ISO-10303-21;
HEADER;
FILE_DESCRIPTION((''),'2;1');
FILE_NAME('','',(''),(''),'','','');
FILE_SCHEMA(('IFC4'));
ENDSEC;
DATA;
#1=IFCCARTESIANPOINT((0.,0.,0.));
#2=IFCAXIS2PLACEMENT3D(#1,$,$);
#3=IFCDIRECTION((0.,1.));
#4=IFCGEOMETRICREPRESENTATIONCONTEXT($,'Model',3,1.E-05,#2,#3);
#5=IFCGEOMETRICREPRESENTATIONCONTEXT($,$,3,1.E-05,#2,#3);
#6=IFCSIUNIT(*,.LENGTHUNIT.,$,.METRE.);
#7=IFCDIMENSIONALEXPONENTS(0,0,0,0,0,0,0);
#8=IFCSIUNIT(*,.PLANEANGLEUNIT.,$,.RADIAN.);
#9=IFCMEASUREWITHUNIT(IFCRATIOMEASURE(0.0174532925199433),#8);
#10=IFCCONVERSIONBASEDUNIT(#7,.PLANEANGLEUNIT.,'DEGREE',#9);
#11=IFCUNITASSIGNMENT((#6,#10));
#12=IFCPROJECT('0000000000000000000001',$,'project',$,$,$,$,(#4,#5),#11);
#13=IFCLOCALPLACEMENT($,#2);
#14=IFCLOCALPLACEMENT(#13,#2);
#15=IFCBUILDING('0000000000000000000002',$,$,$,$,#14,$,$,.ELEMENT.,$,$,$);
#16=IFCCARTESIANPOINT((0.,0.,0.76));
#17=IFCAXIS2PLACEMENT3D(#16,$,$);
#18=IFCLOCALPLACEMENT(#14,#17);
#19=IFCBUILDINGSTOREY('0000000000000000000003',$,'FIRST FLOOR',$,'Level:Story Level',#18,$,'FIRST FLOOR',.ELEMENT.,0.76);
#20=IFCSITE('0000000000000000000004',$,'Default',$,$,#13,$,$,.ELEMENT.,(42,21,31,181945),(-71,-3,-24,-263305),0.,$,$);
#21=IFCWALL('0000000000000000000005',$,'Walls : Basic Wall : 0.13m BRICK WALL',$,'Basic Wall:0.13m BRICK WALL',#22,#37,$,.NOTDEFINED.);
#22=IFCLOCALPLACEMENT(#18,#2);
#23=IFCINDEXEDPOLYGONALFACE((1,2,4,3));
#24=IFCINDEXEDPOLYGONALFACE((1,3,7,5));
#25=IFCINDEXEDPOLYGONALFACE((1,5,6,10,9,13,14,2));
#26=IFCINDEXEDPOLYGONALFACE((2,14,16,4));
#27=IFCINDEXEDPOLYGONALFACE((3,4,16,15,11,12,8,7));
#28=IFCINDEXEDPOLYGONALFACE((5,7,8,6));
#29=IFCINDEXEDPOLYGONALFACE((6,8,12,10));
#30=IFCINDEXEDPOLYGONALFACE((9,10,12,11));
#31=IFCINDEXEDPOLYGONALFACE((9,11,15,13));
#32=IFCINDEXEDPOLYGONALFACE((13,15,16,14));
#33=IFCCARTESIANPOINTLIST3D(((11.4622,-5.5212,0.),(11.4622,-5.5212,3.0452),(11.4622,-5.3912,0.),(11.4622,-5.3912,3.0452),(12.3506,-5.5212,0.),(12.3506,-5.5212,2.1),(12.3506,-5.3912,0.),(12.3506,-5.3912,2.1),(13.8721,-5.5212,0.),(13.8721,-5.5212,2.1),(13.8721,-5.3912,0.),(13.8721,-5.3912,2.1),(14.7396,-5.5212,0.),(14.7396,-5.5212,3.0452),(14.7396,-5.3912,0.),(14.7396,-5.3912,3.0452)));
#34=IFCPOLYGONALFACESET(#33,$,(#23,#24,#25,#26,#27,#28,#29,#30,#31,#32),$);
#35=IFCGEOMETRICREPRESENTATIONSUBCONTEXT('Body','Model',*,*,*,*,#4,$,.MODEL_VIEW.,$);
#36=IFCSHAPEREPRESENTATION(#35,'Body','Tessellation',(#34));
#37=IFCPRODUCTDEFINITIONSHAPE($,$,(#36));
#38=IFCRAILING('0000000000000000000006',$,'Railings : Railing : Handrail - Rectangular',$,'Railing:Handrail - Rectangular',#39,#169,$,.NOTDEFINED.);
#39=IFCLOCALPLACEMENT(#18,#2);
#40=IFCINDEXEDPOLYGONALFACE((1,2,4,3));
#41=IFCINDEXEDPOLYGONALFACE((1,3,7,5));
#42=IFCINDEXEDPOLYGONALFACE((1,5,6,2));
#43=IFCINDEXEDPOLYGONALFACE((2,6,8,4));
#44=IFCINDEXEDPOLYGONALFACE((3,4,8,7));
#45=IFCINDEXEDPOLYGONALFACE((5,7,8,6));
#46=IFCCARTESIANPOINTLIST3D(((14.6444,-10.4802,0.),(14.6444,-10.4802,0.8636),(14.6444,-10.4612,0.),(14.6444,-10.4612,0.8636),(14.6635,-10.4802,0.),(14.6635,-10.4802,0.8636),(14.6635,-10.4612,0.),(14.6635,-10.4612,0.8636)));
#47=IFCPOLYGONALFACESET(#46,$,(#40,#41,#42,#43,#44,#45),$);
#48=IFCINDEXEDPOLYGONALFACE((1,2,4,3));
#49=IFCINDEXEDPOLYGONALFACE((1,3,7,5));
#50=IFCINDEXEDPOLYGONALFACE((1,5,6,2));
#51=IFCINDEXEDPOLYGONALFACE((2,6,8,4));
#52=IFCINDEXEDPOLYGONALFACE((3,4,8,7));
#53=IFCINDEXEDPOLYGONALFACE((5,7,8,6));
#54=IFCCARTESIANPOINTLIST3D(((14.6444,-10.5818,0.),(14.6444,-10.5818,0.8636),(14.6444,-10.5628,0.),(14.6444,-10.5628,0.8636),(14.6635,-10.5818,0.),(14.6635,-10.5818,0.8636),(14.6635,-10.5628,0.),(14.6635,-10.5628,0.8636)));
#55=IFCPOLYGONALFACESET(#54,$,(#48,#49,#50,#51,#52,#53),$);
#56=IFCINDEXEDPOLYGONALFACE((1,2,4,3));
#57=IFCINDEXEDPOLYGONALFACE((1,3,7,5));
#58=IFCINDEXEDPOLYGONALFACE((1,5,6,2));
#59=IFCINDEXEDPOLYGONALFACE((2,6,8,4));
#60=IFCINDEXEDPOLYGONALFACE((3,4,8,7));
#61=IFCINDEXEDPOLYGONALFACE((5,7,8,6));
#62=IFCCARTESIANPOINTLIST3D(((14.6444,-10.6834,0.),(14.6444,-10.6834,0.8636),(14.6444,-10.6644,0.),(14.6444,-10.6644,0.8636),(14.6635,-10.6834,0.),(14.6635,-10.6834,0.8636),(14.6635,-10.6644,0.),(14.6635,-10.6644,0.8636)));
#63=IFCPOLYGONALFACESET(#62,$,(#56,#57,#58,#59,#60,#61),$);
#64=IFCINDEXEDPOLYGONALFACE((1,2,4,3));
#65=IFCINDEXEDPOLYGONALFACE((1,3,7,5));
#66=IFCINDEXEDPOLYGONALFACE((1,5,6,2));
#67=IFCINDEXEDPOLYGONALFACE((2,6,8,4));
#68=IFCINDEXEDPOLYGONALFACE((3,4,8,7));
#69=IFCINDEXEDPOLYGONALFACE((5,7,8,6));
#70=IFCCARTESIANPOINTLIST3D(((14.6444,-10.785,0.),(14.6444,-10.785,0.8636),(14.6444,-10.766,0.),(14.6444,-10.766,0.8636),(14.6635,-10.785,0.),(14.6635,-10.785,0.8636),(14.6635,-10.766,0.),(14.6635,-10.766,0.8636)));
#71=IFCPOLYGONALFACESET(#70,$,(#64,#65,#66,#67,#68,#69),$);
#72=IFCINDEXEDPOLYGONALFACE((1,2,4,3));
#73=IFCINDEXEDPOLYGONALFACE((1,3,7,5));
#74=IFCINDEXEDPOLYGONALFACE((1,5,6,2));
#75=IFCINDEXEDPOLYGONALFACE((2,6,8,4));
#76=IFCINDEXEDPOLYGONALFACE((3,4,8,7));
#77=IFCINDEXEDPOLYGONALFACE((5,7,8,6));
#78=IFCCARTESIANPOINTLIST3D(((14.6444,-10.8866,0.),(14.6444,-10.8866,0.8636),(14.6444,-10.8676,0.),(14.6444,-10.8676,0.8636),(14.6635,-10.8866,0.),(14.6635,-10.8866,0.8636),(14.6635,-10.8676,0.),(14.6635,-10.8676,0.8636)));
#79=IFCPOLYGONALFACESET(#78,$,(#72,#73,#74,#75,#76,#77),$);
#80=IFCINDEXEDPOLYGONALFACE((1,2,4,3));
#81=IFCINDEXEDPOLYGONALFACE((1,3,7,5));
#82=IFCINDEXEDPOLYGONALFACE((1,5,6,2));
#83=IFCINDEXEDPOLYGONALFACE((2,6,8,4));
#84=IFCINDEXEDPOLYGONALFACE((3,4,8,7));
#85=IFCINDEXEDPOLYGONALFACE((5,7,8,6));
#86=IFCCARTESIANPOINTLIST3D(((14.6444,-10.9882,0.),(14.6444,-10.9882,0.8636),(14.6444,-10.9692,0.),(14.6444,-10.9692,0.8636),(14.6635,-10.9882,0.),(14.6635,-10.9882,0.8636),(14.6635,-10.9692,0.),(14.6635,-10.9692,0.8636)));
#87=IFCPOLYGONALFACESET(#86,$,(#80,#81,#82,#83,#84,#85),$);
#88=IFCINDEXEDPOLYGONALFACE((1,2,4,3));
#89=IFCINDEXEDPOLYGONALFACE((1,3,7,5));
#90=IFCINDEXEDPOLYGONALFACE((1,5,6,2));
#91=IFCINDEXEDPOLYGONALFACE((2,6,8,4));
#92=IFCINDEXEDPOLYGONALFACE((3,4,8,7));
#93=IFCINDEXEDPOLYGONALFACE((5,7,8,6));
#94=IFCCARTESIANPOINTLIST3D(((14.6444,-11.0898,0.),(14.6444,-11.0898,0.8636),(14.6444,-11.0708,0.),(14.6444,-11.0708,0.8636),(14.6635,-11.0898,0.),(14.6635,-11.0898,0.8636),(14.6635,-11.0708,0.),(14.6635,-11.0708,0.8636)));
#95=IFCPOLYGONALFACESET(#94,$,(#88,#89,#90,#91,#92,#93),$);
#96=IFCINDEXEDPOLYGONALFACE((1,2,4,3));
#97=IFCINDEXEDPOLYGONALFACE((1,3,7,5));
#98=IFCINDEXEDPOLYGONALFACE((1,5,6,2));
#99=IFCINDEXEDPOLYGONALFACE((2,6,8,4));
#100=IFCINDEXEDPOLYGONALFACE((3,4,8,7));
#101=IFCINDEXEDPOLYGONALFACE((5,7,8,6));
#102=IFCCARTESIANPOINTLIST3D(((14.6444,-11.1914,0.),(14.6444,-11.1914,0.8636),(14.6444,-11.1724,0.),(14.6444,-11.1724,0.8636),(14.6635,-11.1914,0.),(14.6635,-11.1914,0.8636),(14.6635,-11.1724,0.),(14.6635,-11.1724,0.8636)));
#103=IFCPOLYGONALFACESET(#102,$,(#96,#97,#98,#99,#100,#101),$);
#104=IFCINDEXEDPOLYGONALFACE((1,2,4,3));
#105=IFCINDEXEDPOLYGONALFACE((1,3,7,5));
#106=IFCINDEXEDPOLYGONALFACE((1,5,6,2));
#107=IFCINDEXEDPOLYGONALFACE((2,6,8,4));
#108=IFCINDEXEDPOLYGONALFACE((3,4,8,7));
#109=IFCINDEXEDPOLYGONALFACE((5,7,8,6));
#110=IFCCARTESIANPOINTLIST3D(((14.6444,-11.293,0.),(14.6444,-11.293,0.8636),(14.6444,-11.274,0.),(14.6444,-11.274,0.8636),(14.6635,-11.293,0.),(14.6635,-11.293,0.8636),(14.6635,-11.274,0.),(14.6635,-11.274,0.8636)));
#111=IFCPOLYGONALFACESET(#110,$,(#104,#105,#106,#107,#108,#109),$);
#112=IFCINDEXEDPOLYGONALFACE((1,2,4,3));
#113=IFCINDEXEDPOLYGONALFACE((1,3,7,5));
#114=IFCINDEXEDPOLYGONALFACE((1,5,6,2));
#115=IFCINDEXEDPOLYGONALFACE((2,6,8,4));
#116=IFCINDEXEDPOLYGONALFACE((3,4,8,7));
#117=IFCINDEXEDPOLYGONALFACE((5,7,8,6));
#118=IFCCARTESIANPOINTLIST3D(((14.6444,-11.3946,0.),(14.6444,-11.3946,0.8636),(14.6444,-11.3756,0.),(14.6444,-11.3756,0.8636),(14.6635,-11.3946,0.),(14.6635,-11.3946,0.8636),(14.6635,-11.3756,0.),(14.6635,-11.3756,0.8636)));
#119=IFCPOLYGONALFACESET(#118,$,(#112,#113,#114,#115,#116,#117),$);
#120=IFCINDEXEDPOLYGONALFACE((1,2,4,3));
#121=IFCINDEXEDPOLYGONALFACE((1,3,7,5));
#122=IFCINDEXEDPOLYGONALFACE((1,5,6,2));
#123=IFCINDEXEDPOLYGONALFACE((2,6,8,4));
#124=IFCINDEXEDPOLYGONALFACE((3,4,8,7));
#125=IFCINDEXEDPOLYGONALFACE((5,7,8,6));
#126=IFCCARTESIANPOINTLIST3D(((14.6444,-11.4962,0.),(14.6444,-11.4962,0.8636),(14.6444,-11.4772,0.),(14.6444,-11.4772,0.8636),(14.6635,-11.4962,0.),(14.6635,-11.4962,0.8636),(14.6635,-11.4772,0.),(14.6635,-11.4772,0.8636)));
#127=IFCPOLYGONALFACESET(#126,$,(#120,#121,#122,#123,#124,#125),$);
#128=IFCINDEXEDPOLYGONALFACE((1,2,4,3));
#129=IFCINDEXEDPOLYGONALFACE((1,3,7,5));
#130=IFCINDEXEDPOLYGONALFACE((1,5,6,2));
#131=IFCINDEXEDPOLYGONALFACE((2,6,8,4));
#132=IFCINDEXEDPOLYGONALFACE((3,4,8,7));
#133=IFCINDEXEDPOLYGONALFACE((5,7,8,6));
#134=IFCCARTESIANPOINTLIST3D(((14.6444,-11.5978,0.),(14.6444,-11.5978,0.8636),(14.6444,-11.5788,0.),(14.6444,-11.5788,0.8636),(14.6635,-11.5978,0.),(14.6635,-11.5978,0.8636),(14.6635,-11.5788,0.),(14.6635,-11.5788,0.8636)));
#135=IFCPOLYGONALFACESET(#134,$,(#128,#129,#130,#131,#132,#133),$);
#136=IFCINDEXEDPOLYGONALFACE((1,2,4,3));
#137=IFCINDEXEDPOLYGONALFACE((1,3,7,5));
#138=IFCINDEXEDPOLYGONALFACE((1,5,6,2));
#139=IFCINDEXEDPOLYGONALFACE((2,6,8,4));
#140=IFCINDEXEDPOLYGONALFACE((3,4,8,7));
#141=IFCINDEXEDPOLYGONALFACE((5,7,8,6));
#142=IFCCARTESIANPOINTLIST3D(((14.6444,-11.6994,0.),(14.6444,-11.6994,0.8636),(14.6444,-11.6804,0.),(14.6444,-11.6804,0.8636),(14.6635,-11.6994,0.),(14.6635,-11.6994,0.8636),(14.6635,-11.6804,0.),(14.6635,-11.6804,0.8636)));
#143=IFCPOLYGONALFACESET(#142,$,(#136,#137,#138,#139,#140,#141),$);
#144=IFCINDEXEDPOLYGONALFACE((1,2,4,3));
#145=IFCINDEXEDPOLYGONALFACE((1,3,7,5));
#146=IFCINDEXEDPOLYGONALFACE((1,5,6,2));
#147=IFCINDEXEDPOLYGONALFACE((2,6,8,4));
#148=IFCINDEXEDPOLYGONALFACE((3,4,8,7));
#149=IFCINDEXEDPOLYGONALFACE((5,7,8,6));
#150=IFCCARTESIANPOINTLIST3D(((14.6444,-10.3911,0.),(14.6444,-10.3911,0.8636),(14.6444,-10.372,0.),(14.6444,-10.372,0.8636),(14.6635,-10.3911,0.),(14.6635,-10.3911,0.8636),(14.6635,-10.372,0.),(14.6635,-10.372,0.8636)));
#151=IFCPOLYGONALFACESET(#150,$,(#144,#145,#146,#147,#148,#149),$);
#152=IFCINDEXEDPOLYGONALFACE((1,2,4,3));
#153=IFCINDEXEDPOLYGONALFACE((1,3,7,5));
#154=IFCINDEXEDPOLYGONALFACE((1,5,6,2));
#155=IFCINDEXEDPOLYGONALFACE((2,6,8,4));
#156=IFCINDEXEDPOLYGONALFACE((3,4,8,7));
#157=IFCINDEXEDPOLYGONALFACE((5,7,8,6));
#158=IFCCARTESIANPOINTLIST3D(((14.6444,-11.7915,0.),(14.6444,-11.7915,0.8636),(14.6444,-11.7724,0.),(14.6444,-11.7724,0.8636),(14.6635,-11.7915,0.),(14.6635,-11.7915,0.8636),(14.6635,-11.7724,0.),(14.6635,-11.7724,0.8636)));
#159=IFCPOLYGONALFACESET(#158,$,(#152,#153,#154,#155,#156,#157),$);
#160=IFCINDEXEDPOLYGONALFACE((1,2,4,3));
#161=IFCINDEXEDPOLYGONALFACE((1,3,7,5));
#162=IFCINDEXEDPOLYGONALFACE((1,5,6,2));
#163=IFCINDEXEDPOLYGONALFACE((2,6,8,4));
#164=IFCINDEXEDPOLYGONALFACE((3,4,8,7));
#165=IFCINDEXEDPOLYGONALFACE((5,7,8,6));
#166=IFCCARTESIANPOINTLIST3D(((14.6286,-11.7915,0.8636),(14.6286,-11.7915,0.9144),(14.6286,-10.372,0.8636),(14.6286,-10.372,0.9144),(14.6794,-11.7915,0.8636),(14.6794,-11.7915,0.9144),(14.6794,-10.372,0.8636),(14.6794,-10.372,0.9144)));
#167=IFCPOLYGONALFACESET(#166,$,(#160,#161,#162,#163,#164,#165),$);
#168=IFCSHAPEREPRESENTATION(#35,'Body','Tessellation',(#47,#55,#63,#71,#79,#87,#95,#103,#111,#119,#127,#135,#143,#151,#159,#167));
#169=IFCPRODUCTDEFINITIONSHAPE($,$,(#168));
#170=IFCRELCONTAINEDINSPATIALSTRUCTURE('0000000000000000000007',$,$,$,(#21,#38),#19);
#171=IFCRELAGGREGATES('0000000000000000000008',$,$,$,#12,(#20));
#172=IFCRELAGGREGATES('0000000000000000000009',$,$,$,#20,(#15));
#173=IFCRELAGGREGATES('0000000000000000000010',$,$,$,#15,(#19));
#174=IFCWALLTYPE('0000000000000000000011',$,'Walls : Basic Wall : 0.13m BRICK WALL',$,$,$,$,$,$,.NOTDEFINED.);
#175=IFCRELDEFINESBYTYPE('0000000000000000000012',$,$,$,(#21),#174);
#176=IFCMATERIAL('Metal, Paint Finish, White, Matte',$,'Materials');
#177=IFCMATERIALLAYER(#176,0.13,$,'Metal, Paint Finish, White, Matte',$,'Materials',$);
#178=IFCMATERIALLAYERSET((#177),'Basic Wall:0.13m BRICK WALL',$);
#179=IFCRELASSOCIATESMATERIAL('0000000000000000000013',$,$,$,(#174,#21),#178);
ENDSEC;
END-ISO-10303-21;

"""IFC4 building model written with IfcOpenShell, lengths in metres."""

from ifc_helpers import new_model, entity, si_unit, converted_unit, direction, frame, frame_2d, origin, origin_2d_with_axis, place, context, subcontext, project, spatial, rectangle, extrude, material, layer, layer_set, layer_usage, type_object, element, save


model = new_model("IFC4")

# Units and contexts
model_context = context("Model", 3, precision=1e-05, world=origin(), true_north=direction((0.0, 1.0)))
context_of_model = context(None, 3, precision=1e-05, world=origin(), true_north=direction((0.0, 1.0)))
body_context = subcontext(model_context, "Body", "Model", "MODEL_VIEW")
ifc_project = project(units=[si_unit("LENGTHUNIT", "METRE"), converted_unit("PLANEANGLEUNIT", "DEGREE", entity("IfcRatioMeasure", 0.0174532925199433), si_unit("PLANEANGLEUNIT", "RADIAN"), dimensions=[0, 0, 0, 0, 0, 0, 0])], contexts=[model_context, context_of_model])

# Site, building, storey
site_placement = place(None, origin())
site = spatial("IfcSite", under=ifc_project, at=site_placement, Name="Default", CompositionType="ELEMENT", RefLatitude=(42, 21, 31, 181945), RefLongitude=(-71, -3, -24, -263305), RefElevation=0.0)
building_placement = place(site_placement, origin())
building = spatial("IfcBuilding", under=site, at=building_placement, CompositionType="ELEMENT")
storey_placement = place(building_placement, frame((0.0, 0.0, 0.76)))
storey = spatial("IfcBuildingStorey", under=building, at=storey_placement, Name="FIRST FLOOR", ObjectType="Level:Story Level", LongName="FIRST FLOOR", CompositionType="ELEMENT", Elevation=0.76)

# Wall, opening
ifc_material_1 = material(Name="Metal, Paint Finish, White, Matte", Category="Materials")
ifc_layer_1 = layer(ifc_material_1, 0.13, Name="Metal, Paint Finish, White, Matte", Category="Materials")
ifc_layer_set_1 = layer_set([ifc_layer_1], Name="Basic Wall:0.13m BRICK WALL")
ifc_layer_usage_1 = layer_usage(ifc_layer_set_1, "AXIS2", "NEGATIVE", 0.065)
wall_type_1 = type_object("IfcWallType", Name="Walls : Basic Wall : 0.13m BRICK WALL", PredefinedType="NOTDEFINED", material=ifc_layer_set_1)
wall_1_placement = place(storey_placement, frame((14.7396, -5.4562, 0.0), z_axis=(0.0, 0.0, 1.0), x_axis=(-1.0, 0.0, 0.0)))
wall_1 = element("IfcWall", 1, at=wall_1_placement, inside=storey, type_object=wall_type_1, material=ifc_layer_usage_1, Name="Walls : Basic Wall : 0.13m BRICK WALL", ObjectType="Basic Wall:0.13m BRICK WALL", PredefinedType="NOTDEFINED", context=body_context, shape_type="SweptSolid", body=[
    extrude(rectangle(XDim=3.2774, YDim=0.13, at=frame_2d((1.6387, 0.0), x_axis=(-1.0, 0.0))), origin(), (0.0, 0.0, 1.0), 3.0452),
])
opening_1_placement = place(wall_1_placement, frame((2.389, 0.065, 0.0)))
element("IfcOpeningElement", 2, at=opening_1_placement, cuts=wall_1, ObjectType="Opening", PredefinedType="OPENING", context=body_context, shape_type="SweptSolid", body=[
    extrude(rectangle(XDim=2.1, YDim=1.5215, at=frame_2d((0.0, 0.0), x_axis=(1.0, 0.0))), frame((-0.7607, -0.13, 1.05), z_axis=(0.0, 1.0, 0.0), x_axis=(0.0, 0.0, -1.0)), (0.0, 0.0, 1.0), 0.13),
])

# Railing
railing_placement = place(storey_placement, frame((14.6286, -11.7915, 0.0)))
element("IfcRailing", 3, at=railing_placement, inside=storey, Name="Railings : Railing : Handrail - Rectangular", ObjectType="Railing:Handrail - Rectangular", PredefinedType="NOTDEFINED", context=body_context, shape_type="SweptSolid", body=[
    extrude(rectangle(XDim=0.0191, YDim=0.0191, at=origin_2d_with_axis()), frame((0.0254, 1.3208, 0.0), z_axis=(0.0, 0.0, 1.0), x_axis=(0.0, 1.0, 0.0)), (0.0, 0.0, 1.0), 0.8636),
    extrude(rectangle(XDim=0.0191, YDim=0.0191, at=origin_2d_with_axis()), frame((0.0254, 1.2192, 0.0), z_axis=(0.0, 0.0, 1.0), x_axis=(0.0, 1.0, 0.0)), (0.0, 0.0, 1.0), 0.8636),
    extrude(rectangle(XDim=0.0191, YDim=0.0191, at=origin_2d_with_axis()), frame((0.0254, 1.1176, 0.0), z_axis=(0.0, 0.0, 1.0), x_axis=(0.0, 1.0, 0.0)), (0.0, 0.0, 1.0), 0.8636),
    extrude(rectangle(XDim=0.0191, YDim=0.0191, at=origin_2d_with_axis()), frame((0.0254, 1.016, 0.0), z_axis=(0.0, 0.0, 1.0), x_axis=(0.0, 1.0, 0.0)), (0.0, 0.0, 1.0), 0.8636),
    extrude(rectangle(XDim=0.0191, YDim=0.0191, at=origin_2d_with_axis()), frame((0.0254, 0.9144, 0.0), z_axis=(0.0, 0.0, 1.0), x_axis=(0.0, 1.0, 0.0)), (0.0, 0.0, 1.0), 0.8636),
    extrude(rectangle(XDim=0.0191, YDim=0.0191, at=origin_2d_with_axis()), frame((0.0254, 0.8128, 0.0), z_axis=(0.0, 0.0, 1.0), x_axis=(0.0, 1.0, 0.0)), (0.0, 0.0, 1.0), 0.8636),
    extrude(rectangle(XDim=0.0191, YDim=0.0191, at=origin_2d_with_axis()), frame((0.0254, 0.7112, 0.0), z_axis=(0.0, 0.0, 1.0), x_axis=(0.0, 1.0, 0.0)), (0.0, 0.0, 1.0), 0.8636),
    extrude(rectangle(XDim=0.0191, YDim=0.0191, at=origin_2d_with_axis()), frame((0.0254, 0.6096, 0.0), z_axis=(0.0, 0.0, 1.0), x_axis=(0.0, 1.0, 0.0)), (0.0, 0.0, 1.0), 0.8636),
    extrude(rectangle(XDim=0.0191, YDim=0.0191, at=origin_2d_with_axis()), frame((0.0254, 0.508, 0.0), z_axis=(0.0, 0.0, 1.0), x_axis=(0.0, 1.0, 0.0)), (0.0, 0.0, 1.0), 0.8636),
    extrude(rectangle(XDim=0.0191, YDim=0.0191, at=origin_2d_with_axis()), frame((0.0254, 0.4064, 0.0), z_axis=(0.0, 0.0, 1.0), x_axis=(0.0, 1.0, 0.0)), (0.0, 0.0, 1.0), 0.8636),
    extrude(rectangle(XDim=0.0191, YDim=0.0191, at=origin_2d_with_axis()), frame((0.0254, 0.3048, 0.0), z_axis=(0.0, 0.0, 1.0), x_axis=(0.0, 1.0, 0.0)), (0.0, 0.0, 1.0), 0.8636),
    extrude(rectangle(XDim=0.0191, YDim=0.0191, at=origin_2d_with_axis()), frame((0.0254, 0.2032, 0.0), z_axis=(0.0, 0.0, 1.0), x_axis=(0.0, 1.0, 0.0)), (0.0, 0.0, 1.0), 0.8636),
    extrude(rectangle(XDim=0.0191, YDim=0.0191, at=origin_2d_with_axis()), frame((0.0254, 0.1016, 0.0), z_axis=(0.0, 0.0, 1.0), x_axis=(0.0, 1.0, 0.0)), (0.0, 0.0, 1.0), 0.8636),
    extrude(rectangle(XDim=0.0191, YDim=0.0191, at=origin_2d_with_axis()), frame((0.0254, 1.41, 0.0), z_axis=(0.0, 0.0, 1.0), x_axis=(0.0, 1.0, 0.0)), (0.0, 0.0, 1.0), 0.8636),
    extrude(rectangle(XDim=0.0191, YDim=0.0191, at=origin_2d_with_axis()), frame((0.0254, 0.0095, 0.0), z_axis=(0.0, 0.0, 1.0), x_axis=(0.0, 1.0, 0.0)), (0.0, 0.0, 1.0), 0.8636),
    extrude(rectangle(XDim=1.4195, YDim=0.0508, at=frame_2d((0.0, 0.0), x_axis=(1.0, 0.0))), frame((0.0254, 0.7097, 0.8636), z_axis=(0.0, 0.0, 1.0), x_axis=(0.0, 1.0, 0.0)), (0.0, 0.0, 1.0), 0.0508),
])

save(model, "model.ifc")
